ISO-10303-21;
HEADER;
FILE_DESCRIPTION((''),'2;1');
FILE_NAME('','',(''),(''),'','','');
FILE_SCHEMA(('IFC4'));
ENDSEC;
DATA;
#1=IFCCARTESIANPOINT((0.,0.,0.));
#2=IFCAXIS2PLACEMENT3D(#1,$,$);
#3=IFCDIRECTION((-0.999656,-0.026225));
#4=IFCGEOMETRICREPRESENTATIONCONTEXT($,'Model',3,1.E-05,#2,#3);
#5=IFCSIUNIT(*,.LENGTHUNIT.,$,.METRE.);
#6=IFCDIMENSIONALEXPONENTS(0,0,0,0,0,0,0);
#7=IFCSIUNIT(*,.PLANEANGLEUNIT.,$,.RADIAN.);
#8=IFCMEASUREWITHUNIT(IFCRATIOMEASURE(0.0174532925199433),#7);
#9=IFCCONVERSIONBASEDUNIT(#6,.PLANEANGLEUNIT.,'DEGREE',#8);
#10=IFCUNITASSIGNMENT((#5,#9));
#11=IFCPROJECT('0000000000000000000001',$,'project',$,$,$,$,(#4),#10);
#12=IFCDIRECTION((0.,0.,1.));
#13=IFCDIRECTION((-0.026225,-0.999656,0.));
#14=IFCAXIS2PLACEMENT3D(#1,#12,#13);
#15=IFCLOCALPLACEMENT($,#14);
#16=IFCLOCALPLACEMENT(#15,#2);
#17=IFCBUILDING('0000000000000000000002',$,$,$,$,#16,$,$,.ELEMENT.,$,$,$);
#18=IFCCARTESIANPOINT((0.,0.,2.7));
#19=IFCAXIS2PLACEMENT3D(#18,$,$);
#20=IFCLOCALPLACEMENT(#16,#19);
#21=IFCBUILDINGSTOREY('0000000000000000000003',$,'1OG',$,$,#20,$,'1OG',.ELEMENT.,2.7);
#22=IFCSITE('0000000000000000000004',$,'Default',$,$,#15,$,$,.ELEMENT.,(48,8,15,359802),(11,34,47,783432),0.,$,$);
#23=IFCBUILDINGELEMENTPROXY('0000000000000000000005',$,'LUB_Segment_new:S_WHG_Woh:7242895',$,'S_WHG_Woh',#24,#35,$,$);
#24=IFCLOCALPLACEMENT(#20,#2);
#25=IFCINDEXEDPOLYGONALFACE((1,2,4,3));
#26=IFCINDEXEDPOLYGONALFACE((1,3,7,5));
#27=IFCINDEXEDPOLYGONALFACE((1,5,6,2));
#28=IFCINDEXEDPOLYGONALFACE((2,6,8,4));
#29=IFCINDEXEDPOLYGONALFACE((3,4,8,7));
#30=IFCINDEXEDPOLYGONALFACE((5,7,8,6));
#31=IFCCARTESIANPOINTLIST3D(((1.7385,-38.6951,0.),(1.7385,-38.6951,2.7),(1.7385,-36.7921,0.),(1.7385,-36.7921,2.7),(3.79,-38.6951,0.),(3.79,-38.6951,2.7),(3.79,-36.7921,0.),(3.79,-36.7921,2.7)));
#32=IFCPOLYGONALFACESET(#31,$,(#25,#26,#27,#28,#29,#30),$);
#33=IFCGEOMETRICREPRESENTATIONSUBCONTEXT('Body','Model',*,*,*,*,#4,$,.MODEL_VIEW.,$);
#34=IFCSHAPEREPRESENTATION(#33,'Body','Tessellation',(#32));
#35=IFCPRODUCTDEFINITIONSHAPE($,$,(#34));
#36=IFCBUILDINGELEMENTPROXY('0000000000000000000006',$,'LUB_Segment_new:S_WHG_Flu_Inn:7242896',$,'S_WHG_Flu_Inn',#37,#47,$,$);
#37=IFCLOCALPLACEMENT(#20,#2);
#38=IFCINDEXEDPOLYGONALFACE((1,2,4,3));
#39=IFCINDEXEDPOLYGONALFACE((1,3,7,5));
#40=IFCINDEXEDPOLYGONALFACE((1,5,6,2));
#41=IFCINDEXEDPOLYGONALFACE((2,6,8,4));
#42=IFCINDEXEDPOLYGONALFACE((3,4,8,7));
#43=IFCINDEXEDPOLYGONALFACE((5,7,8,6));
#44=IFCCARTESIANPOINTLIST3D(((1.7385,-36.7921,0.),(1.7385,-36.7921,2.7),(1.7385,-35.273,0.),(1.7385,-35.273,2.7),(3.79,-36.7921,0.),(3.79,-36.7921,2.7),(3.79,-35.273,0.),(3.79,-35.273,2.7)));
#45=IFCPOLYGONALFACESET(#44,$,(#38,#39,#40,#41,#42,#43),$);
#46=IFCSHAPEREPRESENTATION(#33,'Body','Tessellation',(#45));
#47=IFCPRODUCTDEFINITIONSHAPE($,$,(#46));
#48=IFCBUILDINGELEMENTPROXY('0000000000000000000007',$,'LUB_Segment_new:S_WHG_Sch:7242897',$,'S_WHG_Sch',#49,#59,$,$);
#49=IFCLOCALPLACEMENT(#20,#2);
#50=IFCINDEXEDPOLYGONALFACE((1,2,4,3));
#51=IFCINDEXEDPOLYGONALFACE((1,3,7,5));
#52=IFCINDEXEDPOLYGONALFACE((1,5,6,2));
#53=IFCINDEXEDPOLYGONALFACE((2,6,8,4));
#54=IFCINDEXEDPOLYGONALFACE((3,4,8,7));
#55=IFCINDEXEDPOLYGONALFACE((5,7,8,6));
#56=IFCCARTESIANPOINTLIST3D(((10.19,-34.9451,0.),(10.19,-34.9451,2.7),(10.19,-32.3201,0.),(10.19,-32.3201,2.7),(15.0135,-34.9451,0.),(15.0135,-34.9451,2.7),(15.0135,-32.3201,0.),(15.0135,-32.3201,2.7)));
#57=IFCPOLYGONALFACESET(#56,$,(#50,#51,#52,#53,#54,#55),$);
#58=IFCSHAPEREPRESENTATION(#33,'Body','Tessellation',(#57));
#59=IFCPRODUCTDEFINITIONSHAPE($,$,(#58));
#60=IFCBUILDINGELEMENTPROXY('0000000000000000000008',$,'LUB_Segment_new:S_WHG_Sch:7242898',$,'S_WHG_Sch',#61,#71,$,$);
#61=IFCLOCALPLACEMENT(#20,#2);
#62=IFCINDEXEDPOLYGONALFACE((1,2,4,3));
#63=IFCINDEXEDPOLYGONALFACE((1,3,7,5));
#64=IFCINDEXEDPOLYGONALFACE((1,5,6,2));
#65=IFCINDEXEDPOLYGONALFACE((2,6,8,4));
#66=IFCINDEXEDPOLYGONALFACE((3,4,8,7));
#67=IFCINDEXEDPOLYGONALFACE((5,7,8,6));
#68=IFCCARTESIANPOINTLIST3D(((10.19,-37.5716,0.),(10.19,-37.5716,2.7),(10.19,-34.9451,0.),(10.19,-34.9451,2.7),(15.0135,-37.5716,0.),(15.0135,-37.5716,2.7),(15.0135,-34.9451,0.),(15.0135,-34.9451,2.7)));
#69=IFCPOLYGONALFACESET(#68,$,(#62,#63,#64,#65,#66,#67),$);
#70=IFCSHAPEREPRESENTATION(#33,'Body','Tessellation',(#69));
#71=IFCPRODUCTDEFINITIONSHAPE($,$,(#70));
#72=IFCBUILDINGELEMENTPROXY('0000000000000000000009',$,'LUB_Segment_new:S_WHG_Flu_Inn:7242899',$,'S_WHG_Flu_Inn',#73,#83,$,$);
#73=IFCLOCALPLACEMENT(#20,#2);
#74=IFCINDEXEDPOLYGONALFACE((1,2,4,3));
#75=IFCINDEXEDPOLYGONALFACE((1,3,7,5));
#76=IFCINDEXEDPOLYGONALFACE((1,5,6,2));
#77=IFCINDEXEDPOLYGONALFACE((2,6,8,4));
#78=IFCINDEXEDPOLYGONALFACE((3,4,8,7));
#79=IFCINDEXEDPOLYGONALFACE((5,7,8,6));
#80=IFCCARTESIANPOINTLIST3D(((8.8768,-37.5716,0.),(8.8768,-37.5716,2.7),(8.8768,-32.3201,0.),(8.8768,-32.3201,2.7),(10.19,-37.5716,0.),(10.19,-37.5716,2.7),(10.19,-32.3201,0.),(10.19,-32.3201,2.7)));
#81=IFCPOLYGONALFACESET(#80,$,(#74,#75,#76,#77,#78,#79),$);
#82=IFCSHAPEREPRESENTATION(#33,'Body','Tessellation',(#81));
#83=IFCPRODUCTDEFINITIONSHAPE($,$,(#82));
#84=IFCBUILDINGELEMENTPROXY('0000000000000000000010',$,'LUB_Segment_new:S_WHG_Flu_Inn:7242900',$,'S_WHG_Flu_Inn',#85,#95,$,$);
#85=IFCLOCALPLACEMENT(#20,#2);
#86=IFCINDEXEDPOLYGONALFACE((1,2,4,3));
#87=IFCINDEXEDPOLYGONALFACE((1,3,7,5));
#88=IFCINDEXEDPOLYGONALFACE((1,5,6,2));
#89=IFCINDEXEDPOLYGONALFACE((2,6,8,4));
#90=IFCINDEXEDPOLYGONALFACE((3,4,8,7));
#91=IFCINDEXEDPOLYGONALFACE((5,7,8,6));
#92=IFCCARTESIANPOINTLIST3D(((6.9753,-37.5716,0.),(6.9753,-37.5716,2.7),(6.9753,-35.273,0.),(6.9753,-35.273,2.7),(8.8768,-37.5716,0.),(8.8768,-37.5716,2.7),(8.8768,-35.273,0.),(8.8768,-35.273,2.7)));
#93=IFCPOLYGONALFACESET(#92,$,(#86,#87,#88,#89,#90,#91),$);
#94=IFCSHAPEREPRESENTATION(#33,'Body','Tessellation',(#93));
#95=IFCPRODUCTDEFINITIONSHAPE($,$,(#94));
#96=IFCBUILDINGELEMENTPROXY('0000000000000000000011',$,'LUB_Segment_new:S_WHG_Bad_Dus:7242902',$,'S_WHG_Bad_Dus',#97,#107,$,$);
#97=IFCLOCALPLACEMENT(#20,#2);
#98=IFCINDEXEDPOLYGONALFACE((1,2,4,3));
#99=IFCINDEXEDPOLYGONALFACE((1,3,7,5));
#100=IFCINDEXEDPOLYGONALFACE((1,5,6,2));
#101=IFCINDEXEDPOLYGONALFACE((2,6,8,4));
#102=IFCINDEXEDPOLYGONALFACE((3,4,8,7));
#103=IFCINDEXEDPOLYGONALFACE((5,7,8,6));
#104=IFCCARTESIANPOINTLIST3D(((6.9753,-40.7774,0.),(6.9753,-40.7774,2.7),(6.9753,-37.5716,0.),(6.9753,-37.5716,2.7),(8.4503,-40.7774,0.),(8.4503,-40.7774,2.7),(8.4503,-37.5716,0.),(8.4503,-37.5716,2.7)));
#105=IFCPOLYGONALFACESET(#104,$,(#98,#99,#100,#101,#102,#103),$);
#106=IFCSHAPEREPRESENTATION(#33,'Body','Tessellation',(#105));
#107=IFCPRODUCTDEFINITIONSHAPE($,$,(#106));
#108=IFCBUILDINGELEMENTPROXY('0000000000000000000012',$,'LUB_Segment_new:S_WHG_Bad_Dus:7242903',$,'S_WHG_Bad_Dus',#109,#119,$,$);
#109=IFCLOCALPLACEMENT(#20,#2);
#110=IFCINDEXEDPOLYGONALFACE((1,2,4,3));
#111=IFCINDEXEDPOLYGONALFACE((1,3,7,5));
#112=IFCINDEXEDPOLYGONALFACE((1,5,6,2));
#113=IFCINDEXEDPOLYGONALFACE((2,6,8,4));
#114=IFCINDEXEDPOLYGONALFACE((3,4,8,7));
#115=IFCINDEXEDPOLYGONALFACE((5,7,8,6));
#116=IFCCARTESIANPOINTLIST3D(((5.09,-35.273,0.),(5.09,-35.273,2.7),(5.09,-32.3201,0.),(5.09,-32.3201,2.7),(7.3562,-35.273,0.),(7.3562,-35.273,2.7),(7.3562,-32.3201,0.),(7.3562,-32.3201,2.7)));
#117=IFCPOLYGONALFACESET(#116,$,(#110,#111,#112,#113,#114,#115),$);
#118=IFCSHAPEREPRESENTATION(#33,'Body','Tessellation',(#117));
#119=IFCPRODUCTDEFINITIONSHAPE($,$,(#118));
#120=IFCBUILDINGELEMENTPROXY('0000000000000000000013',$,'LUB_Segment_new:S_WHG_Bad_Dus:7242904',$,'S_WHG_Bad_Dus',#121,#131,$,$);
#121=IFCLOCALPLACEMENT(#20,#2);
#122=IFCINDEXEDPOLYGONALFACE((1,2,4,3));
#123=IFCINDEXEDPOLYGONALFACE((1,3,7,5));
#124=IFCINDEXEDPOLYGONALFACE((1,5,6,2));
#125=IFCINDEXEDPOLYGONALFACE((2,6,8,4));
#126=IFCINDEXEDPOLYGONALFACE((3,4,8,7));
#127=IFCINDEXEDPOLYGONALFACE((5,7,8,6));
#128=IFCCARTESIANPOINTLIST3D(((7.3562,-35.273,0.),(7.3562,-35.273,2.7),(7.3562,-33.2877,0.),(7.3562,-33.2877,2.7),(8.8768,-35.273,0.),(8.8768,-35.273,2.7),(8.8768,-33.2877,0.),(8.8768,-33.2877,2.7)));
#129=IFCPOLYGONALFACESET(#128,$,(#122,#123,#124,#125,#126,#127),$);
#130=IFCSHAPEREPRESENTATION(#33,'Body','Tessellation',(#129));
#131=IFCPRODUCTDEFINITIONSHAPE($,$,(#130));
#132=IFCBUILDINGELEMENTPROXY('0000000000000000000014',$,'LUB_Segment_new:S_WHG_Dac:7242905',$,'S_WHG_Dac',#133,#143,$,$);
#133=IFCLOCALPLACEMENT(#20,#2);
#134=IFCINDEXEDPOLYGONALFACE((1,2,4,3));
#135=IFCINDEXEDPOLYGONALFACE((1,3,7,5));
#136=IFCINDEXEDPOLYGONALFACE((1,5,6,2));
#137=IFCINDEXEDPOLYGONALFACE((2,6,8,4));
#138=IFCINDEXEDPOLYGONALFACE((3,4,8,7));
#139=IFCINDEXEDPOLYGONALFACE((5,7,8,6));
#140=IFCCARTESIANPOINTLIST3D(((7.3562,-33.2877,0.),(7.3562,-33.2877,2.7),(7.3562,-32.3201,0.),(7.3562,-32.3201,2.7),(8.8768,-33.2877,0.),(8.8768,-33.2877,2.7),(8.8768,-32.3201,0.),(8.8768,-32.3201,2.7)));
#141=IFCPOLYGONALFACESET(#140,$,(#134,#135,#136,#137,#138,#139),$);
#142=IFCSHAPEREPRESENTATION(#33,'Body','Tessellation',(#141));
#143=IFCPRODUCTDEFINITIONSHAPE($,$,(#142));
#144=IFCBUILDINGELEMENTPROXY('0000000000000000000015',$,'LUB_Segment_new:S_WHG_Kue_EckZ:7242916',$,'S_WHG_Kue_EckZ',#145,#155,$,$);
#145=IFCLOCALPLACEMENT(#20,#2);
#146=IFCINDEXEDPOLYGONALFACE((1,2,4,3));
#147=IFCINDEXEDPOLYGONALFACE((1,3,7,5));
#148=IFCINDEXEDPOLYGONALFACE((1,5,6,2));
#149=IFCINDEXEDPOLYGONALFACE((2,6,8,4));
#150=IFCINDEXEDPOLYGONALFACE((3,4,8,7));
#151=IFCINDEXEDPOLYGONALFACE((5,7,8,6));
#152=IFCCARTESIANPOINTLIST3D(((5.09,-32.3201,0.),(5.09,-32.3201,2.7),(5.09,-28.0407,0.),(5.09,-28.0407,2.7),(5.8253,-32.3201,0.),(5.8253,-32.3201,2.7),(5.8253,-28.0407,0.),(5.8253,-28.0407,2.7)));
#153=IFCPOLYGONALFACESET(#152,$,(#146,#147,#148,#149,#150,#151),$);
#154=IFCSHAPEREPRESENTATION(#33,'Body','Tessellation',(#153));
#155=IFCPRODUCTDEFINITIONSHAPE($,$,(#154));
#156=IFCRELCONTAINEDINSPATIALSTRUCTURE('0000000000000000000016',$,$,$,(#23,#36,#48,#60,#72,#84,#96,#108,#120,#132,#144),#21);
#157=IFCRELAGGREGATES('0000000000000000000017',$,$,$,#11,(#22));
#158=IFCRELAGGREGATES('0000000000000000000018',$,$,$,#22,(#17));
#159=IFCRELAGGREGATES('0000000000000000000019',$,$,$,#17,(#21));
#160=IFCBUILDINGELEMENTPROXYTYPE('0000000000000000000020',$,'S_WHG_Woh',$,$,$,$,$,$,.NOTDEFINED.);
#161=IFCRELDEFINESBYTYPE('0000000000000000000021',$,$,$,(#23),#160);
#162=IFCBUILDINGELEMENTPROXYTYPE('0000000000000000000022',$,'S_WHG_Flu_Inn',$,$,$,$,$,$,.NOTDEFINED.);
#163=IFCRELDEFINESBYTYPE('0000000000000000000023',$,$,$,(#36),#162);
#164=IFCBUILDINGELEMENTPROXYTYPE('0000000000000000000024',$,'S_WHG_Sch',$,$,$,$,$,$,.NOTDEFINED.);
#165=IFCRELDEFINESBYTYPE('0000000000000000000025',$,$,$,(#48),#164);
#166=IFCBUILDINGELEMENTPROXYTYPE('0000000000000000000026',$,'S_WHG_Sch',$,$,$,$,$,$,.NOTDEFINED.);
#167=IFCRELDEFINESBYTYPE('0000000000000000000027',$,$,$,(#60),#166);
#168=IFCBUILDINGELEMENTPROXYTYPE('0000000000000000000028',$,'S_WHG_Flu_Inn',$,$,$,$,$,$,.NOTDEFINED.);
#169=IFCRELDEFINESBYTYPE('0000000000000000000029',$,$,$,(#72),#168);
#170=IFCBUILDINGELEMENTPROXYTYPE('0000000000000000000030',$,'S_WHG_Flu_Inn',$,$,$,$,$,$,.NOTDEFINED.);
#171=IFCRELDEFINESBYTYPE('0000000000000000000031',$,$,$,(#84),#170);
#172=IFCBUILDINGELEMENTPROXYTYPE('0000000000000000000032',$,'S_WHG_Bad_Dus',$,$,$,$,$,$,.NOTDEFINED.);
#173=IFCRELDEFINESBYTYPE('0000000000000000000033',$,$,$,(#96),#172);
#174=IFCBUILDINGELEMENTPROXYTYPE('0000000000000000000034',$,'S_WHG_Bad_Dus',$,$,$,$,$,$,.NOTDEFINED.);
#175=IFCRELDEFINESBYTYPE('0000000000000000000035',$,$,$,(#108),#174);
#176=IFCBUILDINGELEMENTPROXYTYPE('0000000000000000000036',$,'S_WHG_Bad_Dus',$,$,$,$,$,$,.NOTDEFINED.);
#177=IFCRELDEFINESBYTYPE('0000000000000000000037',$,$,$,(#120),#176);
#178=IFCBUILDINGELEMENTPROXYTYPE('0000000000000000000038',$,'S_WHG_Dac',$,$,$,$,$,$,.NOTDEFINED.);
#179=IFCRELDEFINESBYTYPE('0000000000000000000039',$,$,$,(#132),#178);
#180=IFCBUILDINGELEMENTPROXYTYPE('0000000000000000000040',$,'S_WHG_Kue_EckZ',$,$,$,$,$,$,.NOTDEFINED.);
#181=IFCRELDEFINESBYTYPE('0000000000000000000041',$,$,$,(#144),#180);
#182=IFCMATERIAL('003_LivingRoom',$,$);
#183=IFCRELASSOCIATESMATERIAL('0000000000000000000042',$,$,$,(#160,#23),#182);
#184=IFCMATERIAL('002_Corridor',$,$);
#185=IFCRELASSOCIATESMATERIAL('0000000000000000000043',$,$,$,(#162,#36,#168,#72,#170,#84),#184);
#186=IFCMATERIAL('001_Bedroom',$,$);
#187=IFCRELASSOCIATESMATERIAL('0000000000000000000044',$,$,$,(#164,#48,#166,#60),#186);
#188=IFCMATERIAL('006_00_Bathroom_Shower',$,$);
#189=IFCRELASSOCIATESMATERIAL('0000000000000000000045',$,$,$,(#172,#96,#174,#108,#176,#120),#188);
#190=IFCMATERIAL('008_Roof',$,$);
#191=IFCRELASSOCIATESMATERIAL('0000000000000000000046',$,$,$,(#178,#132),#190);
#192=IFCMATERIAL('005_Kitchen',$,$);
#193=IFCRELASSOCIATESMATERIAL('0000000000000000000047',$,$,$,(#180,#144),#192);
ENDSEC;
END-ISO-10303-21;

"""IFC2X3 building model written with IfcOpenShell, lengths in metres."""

from ifc_helpers import new_model, entity, si_unit, converted_unit, direction, frame, frame_2d, origin, origin_2d_with_axis, place, context, subcontext, project, spatial, rectangle, extrude, source, transform, mapped, material, type_object, type_shapes, element, save


model = new_model("IFC2X3")

# Units and contexts
model_context = context("Model", 3, precision=1e-05, world=origin(), true_north=direction((-0.999656, -0.026225)))
body_context = subcontext(model_context, "Body", "Model", "MODEL_VIEW")
ifc_project = project(units=[si_unit("LENGTHUNIT", "METRE"), converted_unit("PLANEANGLEUNIT", "DEGREE", entity("IfcRatioMeasure", 0.0174532925199433), si_unit("PLANEANGLEUNIT", "RADIAN"), dimensions=[0, 0, 0, 0, 0, 0, 0])], contexts=[model_context])

# Site, building, storey
site_placement = place(None, frame((0.0, 0.0, 0.0), z_axis=(0.0, 0.0, 1.0), x_axis=(-0.026225, -0.999656, 0.0)))
site = spatial("IfcSite", under=ifc_project, at=site_placement, Name="Default", CompositionType="ELEMENT", RefLatitude=(48, 8, 15, 359802), RefLongitude=(11, 34, 47, 783432), RefElevation=0.0)
building_placement = place(site_placement, origin())
building = spatial("IfcBuilding", under=site, at=building_placement, CompositionType="ELEMENT")
storey_placement = place(building_placement, frame((0.0, 0.0, 2.7)))
storey = spatial("IfcBuildingStorey", under=building, at=storey_placement, Name="1OG", LongName="1OG", CompositionType="ELEMENT", Elevation=2.7)

# Building element proxies
ifc_material_1 = material(Name="001_Bedroom")
ifc_material_2 = material(Name="002_Corridor")
ifc_material_3 = material(Name="006_00_Bathroom_Shower")
ifc_material_4 = material(Name="005_Kitchen")
ifc_material_5 = material(Name="003_LivingRoom")
building_element_proxy_type_1 = type_object("IfcBuildingElementProxyType", Name="S_WHG_Woh", PredefinedType="NOTDEFINED", material=ifc_material_5)
shared_shape_1 = source(origin(), body_context, "Body", "SweptSolid", [
    extrude(rectangle(XDim=2.0515, YDim=1.9029, at=origin_2d_with_axis()), frame((0.0, 0.0, 0.0), z_axis=(0.0, 0.0, 1.0), x_axis=(-1.0, 0.0, 0.0)), (0.0, 0.0, 1.0), 2.7),
])
type_shapes(building_element_proxy_type_1, [shared_shape_1])
proxy_1_placement = place(storey_placement, frame((2.7643, -37.7436, 0.0)))
element("IfcBuildingElementProxy", 1, at=proxy_1_placement, inside=storey, type_object=building_element_proxy_type_1, material=ifc_material_5, Name="LUB_Segment_new:S_WHG_Woh:7242895", ObjectType="S_WHG_Woh", context=body_context, shape_type="MappedRepresentation", body=[
    mapped(shared_shape_1, transform((0.0, 0.0, 0.0), scale=1.0)),
])
building_element_proxy_type_2 = type_object("IfcBuildingElementProxyType", Name="S_WHG_Flu_Inn", PredefinedType="NOTDEFINED", material=ifc_material_2)
shared_shape_2 = source(origin(), body_context, "Body", "SweptSolid", [
    extrude(rectangle(XDim=2.0515, YDim=1.5191, at=origin_2d_with_axis()), frame((0.0, 0.0, 0.0), z_axis=(0.0, 0.0, 1.0), x_axis=(-1.0, 0.0, 0.0)), (0.0, 0.0, 1.0), 2.7),
])
type_shapes(building_element_proxy_type_2, [shared_shape_2])
proxy_2_placement = place(storey_placement, frame((2.7643, -36.0326, 0.0)))
element("IfcBuildingElementProxy", 2, at=proxy_2_placement, inside=storey, type_object=building_element_proxy_type_2, material=ifc_material_2, Name="LUB_Segment_new:S_WHG_Flu_Inn:7242896", ObjectType="S_WHG_Flu_Inn", context=body_context, shape_type="MappedRepresentation", body=[
    mapped(shared_shape_2, transform((0.0, 0.0, 0.0), scale=1.0)),
])
building_element_proxy_type_3 = type_object("IfcBuildingElementProxyType", Name="S_WHG_Sch", PredefinedType="NOTDEFINED", material=ifc_material_1)
shared_shape_3 = source(origin(), body_context, "Body", "SweptSolid", [
    extrude(rectangle(XDim=4.8235, YDim=2.625, at=origin_2d_with_axis()), frame((0.0, 0.0, 0.0), z_axis=(0.0, 0.0, 1.0), x_axis=(-1.0, 0.0, 0.0)), (0.0, 0.0, 1.0), 2.7),
])
type_shapes(building_element_proxy_type_3, [shared_shape_3])
proxy_3_placement = place(storey_placement, frame((12.6018, -33.6326, 0.0)))
element("IfcBuildingElementProxy", 3, at=proxy_3_placement, inside=storey, type_object=building_element_proxy_type_3, material=ifc_material_1, Name="LUB_Segment_new:S_WHG_Sch:7242897", ObjectType="S_WHG_Sch", context=body_context, shape_type="MappedRepresentation", body=[
    mapped(shared_shape_3, transform((0.0, 0.0, 0.0), scale=1.0)),
])
building_element_proxy_type_4 = type_object("IfcBuildingElementProxyType", Name="S_WHG_Sch", PredefinedType="NOTDEFINED", material=ifc_material_1)
shared_shape_4 = source(origin(), body_context, "Body", "SweptSolid", [
    extrude(rectangle(XDim=4.8235, YDim=2.6265, at=origin_2d_with_axis()), frame((0.0, 0.0, 0.0), z_axis=(0.0, 0.0, 1.0), x_axis=(-1.0, 0.0, 0.0)), (0.0, 0.0, 1.0), 2.7),
])
type_shapes(building_element_proxy_type_4, [shared_shape_4])
proxy_4_placement = place(storey_placement, frame((12.6018, -36.2583, 0.0)))
element("IfcBuildingElementProxy", 4, at=proxy_4_placement, inside=storey, type_object=building_element_proxy_type_4, material=ifc_material_1, Name="LUB_Segment_new:S_WHG_Sch:7242898", ObjectType="S_WHG_Sch", context=body_context, shape_type="MappedRepresentation", body=[
    mapped(shared_shape_4, transform((0.0, 0.0, 0.0), scale=1.0)),
])
building_element_proxy_type_5 = type_object("IfcBuildingElementProxyType", Name="S_WHG_Flu_Inn", PredefinedType="NOTDEFINED", material=ifc_material_2)
shared_shape_5 = source(origin(), body_context, "Body", "SweptSolid", [
    extrude(rectangle(XDim=1.3132, YDim=5.2515, at=origin_2d_with_axis()), frame((0.0, 0.0, 0.0), z_axis=(0.0, 0.0, 1.0), x_axis=(-1.0, 0.0, 0.0)), (0.0, 0.0, 1.0), 2.7),
])
type_shapes(building_element_proxy_type_5, [shared_shape_5])
proxy_5_placement = place(storey_placement, frame((9.5334, -34.9458, 0.0)))
element("IfcBuildingElementProxy", 5, at=proxy_5_placement, inside=storey, type_object=building_element_proxy_type_5, material=ifc_material_2, Name="LUB_Segment_new:S_WHG_Flu_Inn:7242899", ObjectType="S_WHG_Flu_Inn", context=body_context, shape_type="MappedRepresentation", body=[
    mapped(shared_shape_5, transform((0.0, 0.0, 0.0), scale=1.0)),
])
building_element_proxy_type_6 = type_object("IfcBuildingElementProxyType", Name="S_WHG_Flu_Inn", PredefinedType="NOTDEFINED", material=ifc_material_2)
shared_shape_6 = source(origin(), body_context, "Body", "SweptSolid", [
    extrude(rectangle(XDim=1.9015, YDim=2.2985, at=origin_2d_with_axis()), frame((0.0, 0.0, 0.0), z_axis=(0.0, 0.0, 1.0), x_axis=(-1.0, 0.0, 0.0)), (0.0, 0.0, 1.0), 2.7),
])
type_shapes(building_element_proxy_type_6, [shared_shape_6])
proxy_6_placement = place(storey_placement, frame((7.926, -36.4223, 0.0)))
element("IfcBuildingElementProxy", 6, at=proxy_6_placement, inside=storey, type_object=building_element_proxy_type_6, material=ifc_material_2, Name="LUB_Segment_new:S_WHG_Flu_Inn:7242900", ObjectType="S_WHG_Flu_Inn", context=body_context, shape_type="MappedRepresentation", body=[
    mapped(shared_shape_6, transform((0.0, 0.0, 0.0), scale=1.0)),
])
building_element_proxy_type_7 = type_object("IfcBuildingElementProxyType", Name="S_WHG_Bad_Dus", PredefinedType="NOTDEFINED", material=ifc_material_3)
shared_shape_7 = source(origin(), body_context, "Body", "SweptSolid", [
    extrude(rectangle(XDim=3.2059, YDim=1.475, at=origin_2d_with_axis()), frame((0.0, 0.0, 0.0), z_axis=(0.0, 0.0, 1.0), x_axis=(0.0, 1.0, 0.0)), (0.0, 0.0, 1.0), 2.7),
])
type_shapes(building_element_proxy_type_7, [shared_shape_7])
proxy_7_placement = place(storey_placement, frame((7.7128, -39.1745, 0.0)))
element("IfcBuildingElementProxy", 7, at=proxy_7_placement, inside=storey, type_object=building_element_proxy_type_7, material=ifc_material_3, Name="LUB_Segment_new:S_WHG_Bad_Dus:7242902", ObjectType="S_WHG_Bad_Dus", context=body_context, shape_type="MappedRepresentation", body=[
    mapped(shared_shape_7, transform((0.0, 0.0, 0.0), scale=1.0)),
])
building_element_proxy_type_8 = type_object("IfcBuildingElementProxyType", Name="S_WHG_Bad_Dus", PredefinedType="NOTDEFINED", material=ifc_material_3)
shared_shape_8 = source(origin(), body_context, "Body", "SweptSolid", [
    extrude(rectangle(XDim=2.9529, YDim=2.2662, at=origin_2d_with_axis()), frame((0.0, 0.0, 0.0), z_axis=(0.0, 0.0, 1.0), x_axis=(0.0, 1.0, 0.0)), (0.0, 0.0, 1.0), 2.7),
])
type_shapes(building_element_proxy_type_8, [shared_shape_8])
proxy_8_placement = place(storey_placement, frame((6.2231, -33.7966, 0.0)))
element("IfcBuildingElementProxy", 8, at=proxy_8_placement, inside=storey, type_object=building_element_proxy_type_8, material=ifc_material_3, Name="LUB_Segment_new:S_WHG_Bad_Dus:7242903", ObjectType="S_WHG_Bad_Dus", context=body_context, shape_type="MappedRepresentation", body=[
    mapped(shared_shape_8, transform((0.0, 0.0, 0.0), scale=1.0)),
])
building_element_proxy_type_9 = type_object("IfcBuildingElementProxyType", Name="S_WHG_Bad_Dus", PredefinedType="NOTDEFINED", material=ifc_material_3)
shared_shape_9 = source(origin(), body_context, "Body", "SweptSolid", [
    extrude(rectangle(XDim=1.9853, YDim=1.5206, at=origin_2d_with_axis()), frame((0.0, 0.0, 0.0), z_axis=(0.0, 0.0, 1.0), x_axis=(0.0, 1.0, 0.0)), (0.0, 0.0, 1.0), 2.7),
])
type_shapes(building_element_proxy_type_9, [shared_shape_9])
proxy_9_placement = place(storey_placement, frame((8.1165, -34.2804, 0.0)))
element("IfcBuildingElementProxy", 9, at=proxy_9_placement, inside=storey, type_object=building_element_proxy_type_9, material=ifc_material_3, Name="LUB_Segment_new:S_WHG_Bad_Dus:7242904", ObjectType="S_WHG_Bad_Dus", context=body_context, shape_type="MappedRepresentation", body=[
    mapped(shared_shape_9, transform((0.0, 0.0, 0.0), scale=1.0)),
])
ifc_material_6 = material(Name="008_Roof")
building_element_proxy_type_10 = type_object("IfcBuildingElementProxyType", Name="S_WHG_Dac", PredefinedType="NOTDEFINED", material=ifc_material_6)
shared_shape_10 = source(origin(), body_context, "Body", "SweptSolid", [
    extrude(rectangle(XDim=0.9676, YDim=1.5206, at=frame_2d((0.0, 0.0), x_axis=(1.0, 0.0))), frame((0.0, 0.0, 0.0), z_axis=(0.0, 0.0, 1.0), x_axis=(0.0, 1.0, 0.0)), (0.0, 0.0, 1.0), 2.7),
])
type_shapes(building_element_proxy_type_10, [shared_shape_10])
proxy_10_placement = place(storey_placement, frame((8.1165, -32.8039, 0.0)))
element("IfcBuildingElementProxy", 10, at=proxy_10_placement, inside=storey, type_object=building_element_proxy_type_10, material=ifc_material_6, Name="LUB_Segment_new:S_WHG_Dac:7242905", ObjectType="S_WHG_Dac", context=body_context, shape_type="MappedRepresentation", body=[
    mapped(shared_shape_10, transform((0.0, 0.0, 0.0), scale=1.0)),
])
building_element_proxy_type_11 = type_object("IfcBuildingElementProxyType", Name="S_WHG_Kue_EckZ", PredefinedType="NOTDEFINED", material=ifc_material_4)
shared_shape_11 = source(origin(), body_context, "Body", "SweptSolid", [
    extrude(rectangle(XDim=4.2794, YDim=0.7353, at=origin_2d_with_axis()), frame((0.0, 0.0, 0.0), z_axis=(0.0, 0.0, 1.0), x_axis=(0.0, 1.0, 0.0)), (0.0, 0.0, 1.0), 2.7),
])
type_shapes(building_element_proxy_type_11, [shared_shape_11])
proxy_11_placement = place(storey_placement, frame((5.4577, -30.1804, 0.0)))
element("IfcBuildingElementProxy", 11, at=proxy_11_placement, inside=storey, type_object=building_element_proxy_type_11, material=ifc_material_4, Name="LUB_Segment_new:S_WHG_Kue_EckZ:7242916", ObjectType="S_WHG_Kue_EckZ", context=body_context, shape_type="MappedRepresentation", body=[
    mapped(shared_shape_11, transform((0.0, 0.0, 0.0), scale=1.0)),
])

save(model, "model.ifc")
